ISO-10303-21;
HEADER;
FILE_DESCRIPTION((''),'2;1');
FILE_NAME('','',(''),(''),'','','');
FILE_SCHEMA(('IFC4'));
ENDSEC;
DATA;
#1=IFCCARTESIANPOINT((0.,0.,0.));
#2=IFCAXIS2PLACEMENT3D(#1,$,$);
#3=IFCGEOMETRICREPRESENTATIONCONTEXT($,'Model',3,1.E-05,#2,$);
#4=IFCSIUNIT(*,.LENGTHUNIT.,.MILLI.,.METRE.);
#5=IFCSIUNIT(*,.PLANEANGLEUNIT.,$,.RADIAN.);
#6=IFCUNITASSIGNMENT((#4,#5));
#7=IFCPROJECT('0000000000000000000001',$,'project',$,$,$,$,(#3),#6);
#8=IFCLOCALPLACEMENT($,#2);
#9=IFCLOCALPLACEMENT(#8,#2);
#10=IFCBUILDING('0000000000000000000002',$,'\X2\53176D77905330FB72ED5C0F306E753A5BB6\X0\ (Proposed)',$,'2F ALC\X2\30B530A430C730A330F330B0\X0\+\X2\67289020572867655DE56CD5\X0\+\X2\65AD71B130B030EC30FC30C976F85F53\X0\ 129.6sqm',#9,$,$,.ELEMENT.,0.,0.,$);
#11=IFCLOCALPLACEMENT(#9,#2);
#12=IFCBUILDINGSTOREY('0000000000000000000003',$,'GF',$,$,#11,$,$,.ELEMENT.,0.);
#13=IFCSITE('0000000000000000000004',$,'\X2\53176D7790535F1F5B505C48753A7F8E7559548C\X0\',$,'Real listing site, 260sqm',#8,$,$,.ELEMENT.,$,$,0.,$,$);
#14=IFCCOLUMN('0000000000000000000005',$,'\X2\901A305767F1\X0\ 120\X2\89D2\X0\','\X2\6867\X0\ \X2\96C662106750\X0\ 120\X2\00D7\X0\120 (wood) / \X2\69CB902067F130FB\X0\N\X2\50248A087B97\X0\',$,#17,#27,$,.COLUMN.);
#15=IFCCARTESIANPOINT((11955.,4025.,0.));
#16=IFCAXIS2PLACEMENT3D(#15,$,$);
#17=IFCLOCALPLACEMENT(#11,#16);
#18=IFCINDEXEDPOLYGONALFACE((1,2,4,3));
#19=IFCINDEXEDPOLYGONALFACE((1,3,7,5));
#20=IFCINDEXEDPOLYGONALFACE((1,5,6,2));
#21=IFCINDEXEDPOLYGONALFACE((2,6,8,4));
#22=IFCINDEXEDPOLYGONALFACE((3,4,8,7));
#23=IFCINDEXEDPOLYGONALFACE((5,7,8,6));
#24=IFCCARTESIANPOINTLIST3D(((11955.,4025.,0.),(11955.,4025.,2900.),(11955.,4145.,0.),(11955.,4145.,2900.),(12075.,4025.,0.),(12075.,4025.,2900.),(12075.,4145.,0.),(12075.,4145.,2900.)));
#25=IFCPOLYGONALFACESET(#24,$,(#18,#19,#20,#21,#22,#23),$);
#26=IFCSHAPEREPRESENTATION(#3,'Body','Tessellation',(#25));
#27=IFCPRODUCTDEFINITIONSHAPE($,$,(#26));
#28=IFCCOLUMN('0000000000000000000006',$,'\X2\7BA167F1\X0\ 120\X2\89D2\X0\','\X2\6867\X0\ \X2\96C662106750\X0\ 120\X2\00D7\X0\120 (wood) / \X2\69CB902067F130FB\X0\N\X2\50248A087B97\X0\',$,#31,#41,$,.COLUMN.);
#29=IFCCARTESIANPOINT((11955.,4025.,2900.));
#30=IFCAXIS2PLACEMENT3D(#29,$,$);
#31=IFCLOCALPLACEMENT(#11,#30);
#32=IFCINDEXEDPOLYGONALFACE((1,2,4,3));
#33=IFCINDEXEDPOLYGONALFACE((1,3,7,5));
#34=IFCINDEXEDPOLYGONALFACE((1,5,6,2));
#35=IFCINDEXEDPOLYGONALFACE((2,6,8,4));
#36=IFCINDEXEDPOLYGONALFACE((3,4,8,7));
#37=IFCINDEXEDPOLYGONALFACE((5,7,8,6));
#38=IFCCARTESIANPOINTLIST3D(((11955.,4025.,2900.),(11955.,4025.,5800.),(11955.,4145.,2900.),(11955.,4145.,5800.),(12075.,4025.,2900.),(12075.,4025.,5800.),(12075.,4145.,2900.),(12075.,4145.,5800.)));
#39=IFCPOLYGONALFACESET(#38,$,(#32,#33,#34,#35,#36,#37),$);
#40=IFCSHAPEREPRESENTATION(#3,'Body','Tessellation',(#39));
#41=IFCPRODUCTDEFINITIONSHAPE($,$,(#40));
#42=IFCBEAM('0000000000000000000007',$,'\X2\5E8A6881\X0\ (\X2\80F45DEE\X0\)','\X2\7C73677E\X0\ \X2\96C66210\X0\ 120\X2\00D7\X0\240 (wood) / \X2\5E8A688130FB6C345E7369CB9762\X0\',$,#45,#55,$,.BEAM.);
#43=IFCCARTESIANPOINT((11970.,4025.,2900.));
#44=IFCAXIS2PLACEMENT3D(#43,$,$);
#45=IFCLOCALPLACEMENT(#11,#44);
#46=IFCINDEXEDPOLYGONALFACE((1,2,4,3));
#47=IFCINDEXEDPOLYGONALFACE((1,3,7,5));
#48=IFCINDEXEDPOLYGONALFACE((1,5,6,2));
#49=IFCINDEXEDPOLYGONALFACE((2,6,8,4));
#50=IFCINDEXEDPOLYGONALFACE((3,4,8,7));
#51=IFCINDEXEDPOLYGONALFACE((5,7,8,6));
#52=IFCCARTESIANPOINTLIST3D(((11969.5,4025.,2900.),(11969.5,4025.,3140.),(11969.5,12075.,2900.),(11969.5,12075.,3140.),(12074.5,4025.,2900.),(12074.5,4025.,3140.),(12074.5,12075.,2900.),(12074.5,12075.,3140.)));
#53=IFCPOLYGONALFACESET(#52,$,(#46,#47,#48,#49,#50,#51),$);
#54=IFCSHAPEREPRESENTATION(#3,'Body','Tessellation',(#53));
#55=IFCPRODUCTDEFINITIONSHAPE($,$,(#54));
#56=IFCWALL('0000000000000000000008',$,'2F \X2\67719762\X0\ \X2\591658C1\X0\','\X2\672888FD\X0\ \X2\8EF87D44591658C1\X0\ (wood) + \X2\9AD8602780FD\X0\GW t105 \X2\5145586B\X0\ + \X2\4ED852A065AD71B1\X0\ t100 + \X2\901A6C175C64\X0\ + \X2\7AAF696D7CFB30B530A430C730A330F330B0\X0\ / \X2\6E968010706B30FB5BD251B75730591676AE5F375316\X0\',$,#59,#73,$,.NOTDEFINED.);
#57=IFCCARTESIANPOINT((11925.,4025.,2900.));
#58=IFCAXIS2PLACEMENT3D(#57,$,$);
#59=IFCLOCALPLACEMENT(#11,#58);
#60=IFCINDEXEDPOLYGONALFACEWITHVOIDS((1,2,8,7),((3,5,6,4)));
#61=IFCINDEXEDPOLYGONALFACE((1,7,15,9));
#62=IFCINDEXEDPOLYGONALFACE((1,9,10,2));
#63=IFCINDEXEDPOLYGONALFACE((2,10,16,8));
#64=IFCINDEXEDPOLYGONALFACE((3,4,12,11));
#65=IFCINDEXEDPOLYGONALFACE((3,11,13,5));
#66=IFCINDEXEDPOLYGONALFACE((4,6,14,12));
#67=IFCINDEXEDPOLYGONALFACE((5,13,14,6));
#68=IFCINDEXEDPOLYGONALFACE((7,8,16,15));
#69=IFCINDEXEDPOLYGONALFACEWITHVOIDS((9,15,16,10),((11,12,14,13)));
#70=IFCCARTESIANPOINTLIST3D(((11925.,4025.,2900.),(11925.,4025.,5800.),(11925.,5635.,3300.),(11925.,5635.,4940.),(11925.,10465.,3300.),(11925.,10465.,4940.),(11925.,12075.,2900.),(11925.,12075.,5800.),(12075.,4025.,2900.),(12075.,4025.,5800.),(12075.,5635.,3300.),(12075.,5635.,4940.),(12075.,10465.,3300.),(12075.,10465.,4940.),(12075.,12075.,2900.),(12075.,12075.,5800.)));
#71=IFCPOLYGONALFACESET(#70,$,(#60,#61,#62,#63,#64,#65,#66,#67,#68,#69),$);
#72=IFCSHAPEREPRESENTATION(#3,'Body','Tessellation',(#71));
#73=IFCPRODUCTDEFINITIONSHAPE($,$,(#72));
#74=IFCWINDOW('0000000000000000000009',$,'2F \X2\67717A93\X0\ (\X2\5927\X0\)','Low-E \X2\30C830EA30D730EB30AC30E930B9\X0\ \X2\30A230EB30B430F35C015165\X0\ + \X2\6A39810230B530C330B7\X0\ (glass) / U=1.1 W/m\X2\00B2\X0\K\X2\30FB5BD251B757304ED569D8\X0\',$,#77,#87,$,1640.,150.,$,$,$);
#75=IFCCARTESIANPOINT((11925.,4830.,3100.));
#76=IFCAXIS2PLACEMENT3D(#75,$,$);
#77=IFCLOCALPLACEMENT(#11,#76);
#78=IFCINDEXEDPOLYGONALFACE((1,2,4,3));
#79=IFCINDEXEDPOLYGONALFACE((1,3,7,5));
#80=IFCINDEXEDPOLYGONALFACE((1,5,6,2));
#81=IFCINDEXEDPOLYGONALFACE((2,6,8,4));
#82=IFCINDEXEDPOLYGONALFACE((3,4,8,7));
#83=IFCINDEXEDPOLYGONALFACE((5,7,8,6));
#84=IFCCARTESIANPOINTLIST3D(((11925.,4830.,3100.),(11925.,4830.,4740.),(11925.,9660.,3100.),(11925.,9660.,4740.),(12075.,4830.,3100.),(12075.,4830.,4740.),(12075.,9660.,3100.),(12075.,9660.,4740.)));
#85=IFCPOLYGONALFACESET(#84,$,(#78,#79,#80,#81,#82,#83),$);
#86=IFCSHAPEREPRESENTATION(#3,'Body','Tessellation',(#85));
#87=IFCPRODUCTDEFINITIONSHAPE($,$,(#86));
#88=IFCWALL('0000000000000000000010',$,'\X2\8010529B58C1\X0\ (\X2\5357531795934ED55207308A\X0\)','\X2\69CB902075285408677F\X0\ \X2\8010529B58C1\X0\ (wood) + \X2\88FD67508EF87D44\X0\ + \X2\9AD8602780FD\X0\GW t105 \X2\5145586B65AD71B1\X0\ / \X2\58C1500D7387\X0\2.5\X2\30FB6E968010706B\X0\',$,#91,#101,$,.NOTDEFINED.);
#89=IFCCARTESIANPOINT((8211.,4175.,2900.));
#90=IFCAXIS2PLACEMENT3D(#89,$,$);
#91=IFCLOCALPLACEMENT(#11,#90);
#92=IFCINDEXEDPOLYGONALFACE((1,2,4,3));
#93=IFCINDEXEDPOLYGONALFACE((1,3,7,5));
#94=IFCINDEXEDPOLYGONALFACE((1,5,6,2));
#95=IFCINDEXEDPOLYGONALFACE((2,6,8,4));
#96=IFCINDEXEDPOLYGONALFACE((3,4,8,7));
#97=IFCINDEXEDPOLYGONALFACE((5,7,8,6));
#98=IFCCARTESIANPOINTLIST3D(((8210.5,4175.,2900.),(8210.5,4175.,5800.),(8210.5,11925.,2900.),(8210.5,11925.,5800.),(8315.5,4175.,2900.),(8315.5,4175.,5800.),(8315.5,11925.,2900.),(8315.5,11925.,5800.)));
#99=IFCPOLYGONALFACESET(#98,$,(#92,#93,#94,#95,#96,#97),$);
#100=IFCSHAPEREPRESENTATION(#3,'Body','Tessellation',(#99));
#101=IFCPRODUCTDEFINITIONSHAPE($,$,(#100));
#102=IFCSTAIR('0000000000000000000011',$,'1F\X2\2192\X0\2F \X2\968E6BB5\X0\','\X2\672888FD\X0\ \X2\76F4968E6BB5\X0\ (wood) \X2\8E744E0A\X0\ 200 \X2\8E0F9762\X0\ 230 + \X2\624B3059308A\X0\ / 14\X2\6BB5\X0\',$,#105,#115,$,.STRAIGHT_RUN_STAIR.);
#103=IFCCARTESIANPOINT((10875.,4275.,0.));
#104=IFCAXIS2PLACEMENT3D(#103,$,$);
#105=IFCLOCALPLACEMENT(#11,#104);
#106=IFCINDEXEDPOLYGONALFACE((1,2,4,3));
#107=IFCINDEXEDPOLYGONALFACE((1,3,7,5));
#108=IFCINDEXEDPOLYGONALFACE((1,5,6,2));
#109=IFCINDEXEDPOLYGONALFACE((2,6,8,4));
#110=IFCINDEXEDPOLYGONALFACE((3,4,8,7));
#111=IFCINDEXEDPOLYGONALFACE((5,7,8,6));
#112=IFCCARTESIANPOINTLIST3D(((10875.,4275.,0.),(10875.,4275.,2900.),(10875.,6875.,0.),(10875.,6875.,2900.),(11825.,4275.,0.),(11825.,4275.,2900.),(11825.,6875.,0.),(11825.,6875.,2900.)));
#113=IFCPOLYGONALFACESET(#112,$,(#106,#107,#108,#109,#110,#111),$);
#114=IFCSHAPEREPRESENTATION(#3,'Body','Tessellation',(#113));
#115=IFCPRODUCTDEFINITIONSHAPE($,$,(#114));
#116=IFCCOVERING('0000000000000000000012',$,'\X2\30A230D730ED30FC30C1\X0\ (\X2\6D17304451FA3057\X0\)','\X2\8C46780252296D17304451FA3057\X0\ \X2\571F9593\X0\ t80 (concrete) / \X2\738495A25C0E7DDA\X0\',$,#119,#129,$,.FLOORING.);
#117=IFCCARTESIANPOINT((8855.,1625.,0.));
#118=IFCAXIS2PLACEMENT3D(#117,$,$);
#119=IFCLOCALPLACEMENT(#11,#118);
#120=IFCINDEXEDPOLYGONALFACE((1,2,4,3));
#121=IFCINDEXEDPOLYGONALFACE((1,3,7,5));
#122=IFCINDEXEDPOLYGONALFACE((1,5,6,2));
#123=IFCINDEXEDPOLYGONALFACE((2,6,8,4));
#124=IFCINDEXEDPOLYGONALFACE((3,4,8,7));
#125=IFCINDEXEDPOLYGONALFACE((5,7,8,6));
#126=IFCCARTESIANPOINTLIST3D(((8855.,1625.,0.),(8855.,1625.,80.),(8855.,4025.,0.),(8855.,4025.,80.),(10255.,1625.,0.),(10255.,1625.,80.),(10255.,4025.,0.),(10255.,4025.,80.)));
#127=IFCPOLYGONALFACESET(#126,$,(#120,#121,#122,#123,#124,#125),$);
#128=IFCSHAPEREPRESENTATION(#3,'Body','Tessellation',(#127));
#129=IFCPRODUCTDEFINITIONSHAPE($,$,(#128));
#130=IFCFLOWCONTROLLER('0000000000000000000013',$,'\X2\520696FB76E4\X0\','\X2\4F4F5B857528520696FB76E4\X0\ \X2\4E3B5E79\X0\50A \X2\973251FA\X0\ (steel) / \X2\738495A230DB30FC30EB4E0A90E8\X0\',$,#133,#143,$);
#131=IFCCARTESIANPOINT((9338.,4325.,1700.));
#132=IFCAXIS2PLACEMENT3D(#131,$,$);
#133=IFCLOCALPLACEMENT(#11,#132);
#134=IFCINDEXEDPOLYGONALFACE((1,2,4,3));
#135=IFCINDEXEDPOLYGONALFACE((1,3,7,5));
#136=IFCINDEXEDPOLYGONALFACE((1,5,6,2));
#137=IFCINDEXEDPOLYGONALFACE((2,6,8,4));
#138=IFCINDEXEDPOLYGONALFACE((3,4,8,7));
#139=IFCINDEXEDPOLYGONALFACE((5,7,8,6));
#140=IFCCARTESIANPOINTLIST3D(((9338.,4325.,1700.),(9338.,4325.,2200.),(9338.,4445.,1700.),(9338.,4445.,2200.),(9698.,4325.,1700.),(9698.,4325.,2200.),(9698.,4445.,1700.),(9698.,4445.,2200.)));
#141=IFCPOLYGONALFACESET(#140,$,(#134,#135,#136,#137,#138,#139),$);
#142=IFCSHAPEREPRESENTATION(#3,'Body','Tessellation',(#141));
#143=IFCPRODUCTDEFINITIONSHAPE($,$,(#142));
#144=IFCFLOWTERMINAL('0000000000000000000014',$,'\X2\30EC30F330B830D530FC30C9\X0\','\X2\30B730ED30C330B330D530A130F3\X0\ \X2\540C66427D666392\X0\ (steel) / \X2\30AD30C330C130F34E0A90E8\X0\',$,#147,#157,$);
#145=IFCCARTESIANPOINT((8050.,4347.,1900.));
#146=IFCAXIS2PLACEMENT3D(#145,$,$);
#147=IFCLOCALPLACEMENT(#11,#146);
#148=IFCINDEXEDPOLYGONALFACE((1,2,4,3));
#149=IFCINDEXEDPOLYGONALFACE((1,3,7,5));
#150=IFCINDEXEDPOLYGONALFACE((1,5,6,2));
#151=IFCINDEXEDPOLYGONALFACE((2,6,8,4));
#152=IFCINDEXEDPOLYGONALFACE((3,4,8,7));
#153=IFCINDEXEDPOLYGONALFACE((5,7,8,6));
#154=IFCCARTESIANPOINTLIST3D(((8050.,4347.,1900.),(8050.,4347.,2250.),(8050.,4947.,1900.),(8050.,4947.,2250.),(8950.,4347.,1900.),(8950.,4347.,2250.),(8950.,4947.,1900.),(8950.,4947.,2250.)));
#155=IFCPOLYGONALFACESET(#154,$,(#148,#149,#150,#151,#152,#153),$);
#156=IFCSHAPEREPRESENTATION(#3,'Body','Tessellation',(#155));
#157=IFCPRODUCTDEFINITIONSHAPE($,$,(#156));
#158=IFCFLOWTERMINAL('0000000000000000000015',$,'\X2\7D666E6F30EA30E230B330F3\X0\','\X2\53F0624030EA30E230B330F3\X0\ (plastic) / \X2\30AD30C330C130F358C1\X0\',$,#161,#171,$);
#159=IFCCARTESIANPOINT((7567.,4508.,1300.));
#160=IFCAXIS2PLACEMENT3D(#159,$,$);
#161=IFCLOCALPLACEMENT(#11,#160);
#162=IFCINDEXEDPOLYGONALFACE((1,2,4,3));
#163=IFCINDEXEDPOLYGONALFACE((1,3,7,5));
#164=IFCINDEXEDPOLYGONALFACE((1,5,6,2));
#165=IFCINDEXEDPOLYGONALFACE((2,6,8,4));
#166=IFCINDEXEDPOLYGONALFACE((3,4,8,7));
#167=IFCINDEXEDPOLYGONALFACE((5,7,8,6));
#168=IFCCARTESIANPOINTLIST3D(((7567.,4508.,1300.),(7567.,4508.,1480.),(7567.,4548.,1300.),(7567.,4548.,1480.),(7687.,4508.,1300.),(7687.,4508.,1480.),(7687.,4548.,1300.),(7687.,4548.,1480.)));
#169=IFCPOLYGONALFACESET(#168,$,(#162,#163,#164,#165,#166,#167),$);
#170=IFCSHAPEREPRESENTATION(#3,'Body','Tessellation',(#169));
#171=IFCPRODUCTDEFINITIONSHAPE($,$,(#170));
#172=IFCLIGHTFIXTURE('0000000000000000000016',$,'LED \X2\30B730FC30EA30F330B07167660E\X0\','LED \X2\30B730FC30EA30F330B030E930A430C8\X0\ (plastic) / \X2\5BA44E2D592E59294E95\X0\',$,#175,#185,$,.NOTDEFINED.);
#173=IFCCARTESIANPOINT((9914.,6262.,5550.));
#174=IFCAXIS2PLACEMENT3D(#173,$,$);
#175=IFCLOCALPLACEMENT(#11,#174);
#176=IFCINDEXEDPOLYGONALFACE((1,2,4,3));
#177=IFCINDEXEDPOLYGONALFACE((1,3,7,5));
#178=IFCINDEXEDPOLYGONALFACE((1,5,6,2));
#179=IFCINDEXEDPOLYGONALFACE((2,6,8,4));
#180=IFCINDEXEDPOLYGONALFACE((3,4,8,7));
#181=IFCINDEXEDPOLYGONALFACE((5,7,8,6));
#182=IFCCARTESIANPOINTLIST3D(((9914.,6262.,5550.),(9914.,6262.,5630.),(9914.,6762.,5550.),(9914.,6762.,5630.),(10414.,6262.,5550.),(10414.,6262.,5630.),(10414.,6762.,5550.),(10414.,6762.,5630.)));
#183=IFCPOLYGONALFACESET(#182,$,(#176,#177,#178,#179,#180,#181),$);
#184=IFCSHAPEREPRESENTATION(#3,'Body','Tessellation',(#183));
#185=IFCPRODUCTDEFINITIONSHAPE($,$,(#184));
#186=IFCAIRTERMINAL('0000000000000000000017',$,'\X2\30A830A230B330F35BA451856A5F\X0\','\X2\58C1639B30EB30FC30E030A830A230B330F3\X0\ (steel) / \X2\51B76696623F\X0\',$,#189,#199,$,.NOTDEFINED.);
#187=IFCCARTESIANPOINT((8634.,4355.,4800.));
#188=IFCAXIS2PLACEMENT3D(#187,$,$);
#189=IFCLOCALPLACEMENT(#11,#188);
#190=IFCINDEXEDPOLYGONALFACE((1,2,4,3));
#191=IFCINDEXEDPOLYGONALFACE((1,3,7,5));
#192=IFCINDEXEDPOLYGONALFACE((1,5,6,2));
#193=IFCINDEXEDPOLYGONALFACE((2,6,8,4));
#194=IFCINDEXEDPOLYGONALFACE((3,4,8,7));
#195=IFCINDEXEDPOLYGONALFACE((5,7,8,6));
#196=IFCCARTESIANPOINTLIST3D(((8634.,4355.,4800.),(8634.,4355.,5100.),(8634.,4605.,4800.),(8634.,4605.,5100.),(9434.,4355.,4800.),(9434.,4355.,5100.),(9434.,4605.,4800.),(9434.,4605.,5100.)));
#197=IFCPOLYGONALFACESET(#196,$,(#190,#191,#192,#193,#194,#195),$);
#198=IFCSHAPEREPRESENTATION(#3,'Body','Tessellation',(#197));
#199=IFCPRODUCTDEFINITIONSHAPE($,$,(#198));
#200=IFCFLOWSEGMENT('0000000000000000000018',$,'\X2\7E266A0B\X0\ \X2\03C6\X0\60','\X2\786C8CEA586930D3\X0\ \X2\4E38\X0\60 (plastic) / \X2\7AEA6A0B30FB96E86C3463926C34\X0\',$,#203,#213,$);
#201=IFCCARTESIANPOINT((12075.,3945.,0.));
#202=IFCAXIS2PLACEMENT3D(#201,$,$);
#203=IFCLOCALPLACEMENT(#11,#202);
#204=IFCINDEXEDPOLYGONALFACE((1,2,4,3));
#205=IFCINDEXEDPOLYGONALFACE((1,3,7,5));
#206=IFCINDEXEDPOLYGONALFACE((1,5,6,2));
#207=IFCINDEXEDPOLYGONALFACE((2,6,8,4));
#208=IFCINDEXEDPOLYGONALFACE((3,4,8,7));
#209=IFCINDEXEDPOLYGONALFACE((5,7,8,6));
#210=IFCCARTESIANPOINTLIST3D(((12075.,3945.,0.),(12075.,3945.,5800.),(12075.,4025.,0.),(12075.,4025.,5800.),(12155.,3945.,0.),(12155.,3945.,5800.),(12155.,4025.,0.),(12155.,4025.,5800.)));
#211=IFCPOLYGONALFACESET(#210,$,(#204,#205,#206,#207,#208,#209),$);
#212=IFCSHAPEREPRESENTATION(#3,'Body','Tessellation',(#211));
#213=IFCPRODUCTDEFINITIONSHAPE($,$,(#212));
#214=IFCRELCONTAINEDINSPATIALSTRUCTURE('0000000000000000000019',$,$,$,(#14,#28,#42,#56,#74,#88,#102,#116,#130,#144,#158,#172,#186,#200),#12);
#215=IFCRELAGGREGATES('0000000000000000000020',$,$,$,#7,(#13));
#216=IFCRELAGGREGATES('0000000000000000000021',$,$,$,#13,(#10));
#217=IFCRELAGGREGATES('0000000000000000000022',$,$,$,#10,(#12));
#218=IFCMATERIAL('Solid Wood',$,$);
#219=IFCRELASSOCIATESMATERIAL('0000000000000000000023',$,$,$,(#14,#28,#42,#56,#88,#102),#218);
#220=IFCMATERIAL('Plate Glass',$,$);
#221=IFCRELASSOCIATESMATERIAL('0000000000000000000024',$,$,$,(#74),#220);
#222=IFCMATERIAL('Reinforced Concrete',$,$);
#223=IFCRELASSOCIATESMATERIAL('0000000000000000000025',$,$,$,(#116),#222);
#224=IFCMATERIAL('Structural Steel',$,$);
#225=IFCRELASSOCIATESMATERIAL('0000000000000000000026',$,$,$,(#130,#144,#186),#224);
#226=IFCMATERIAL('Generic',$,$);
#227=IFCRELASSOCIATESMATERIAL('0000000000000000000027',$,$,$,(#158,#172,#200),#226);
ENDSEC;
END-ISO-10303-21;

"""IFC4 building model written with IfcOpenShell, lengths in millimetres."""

from ifc_helpers import new_model, si_unit, frame, frame_2d, origin, place, context, project, spatial, rectangle, extrude, material, element, fill, save


model = new_model("IFC4")

# Units and contexts
model_context = context("Model", 3, precision=1e-05, world=origin())
ifc_project = project(units=[si_unit("LENGTHUNIT", "METRE", prefix="MILLI"), si_unit("PLANEANGLEUNIT", "RADIAN")], contexts=[model_context])

# Site, building, storey
site_placement = place(None, origin())
site = spatial("IfcSite", under=ifc_project, at=site_placement, Name="北海道弟子屈町美留和", ObjectType="Real listing site, 260sqm", CompositionType="ELEMENT", RefElevation=0.0)
building_placement = place(site_placement, origin())
building = spatial("IfcBuilding", under=site, at=building_placement, Name="北海道・狭小の町家 (Proposed)", ObjectType="2F ALCサイディング+木造在来工法+断熱グレード相当 129.6sqm", CompositionType="ELEMENT", ElevationOfRefHeight=0.0, ElevationOfTerrain=0.0)
storey_placement = place(building_placement, origin())
storey = spatial("IfcBuildingStorey", under=building, at=storey_placement, Name="GF", CompositionType="ELEMENT", Elevation=0.0)

# Columns
ifc_material_1 = material(Name="Solid Wood")
column_1_placement = place(storey_placement, frame((11955.0, 4025.0, 0.0)))
element("IfcColumn", 1, at=column_1_placement, inside=storey, material=ifc_material_1, Name="通し柱 120角", Description="桧 集成材 120×120 (wood) / 構造柱・N値計算", PredefinedType="COLUMN", context=model_context, shape_type="SweptSolid", body=[
    extrude(rectangle(XDim=120.0, YDim=120.0, at=frame_2d((60.0, 60.0))), frame((11955.0, 4025.0, 0.0)), (0.0, 0.0, 1.0), 2900.0),
])
column_2_placement = place(storey_placement, frame((11955.0, 4025.0, 2900.0)))
element("IfcColumn", 2, at=column_2_placement, inside=storey, material=ifc_material_1, Name="管柱 120角", Description="桧 集成材 120×120 (wood) / 構造柱・N値計算", PredefinedType="COLUMN", context=model_context, shape_type="SweptSolid", body=[
    extrude(rectangle(XDim=120.0, YDim=120.0, at=frame_2d((60.0, 60.0))), frame((11955.0, 4025.0, 2900.0)), (0.0, 0.0, 1.0), 2900.0),
])

# Beam
beam_1_placement = place(storey_placement, frame((11970.0, 4025.0, 2900.0)))
element("IfcBeam", 3, at=beam_1_placement, inside=storey, material=ifc_material_1, Name="床梁 (胴差)", Description="米松 集成 120×240 (wood) / 床梁・水平構面", PredefinedType="BEAM", context=model_context, shape_type="SweptSolid", body=[
    extrude(rectangle(XDim=105.0, YDim=8050.0, at=frame_2d((52.0, 4025.0))), frame((11970.0, 4025.0, 2900.0)), (0.0, 0.0, 1.0), 240.0),
])

# Shared definitions
ifc_material_2 = material(Name="Plate Glass")

# Wall, opening, window
wall_1_placement = place(storey_placement, frame((11925.0, 4025.0, 2900.0)))
wall_1 = element("IfcWall", 4, at=wall_1_placement, inside=storey, material=ifc_material_1, Name="2F 東面 外壁", Description="木製 軸組外壁 (wood) + 高性能GW t105 充填 + 付加断熱 t100 + 通気層 + 窯業系サイディング / 準耐火・寒冷地外皮強化", PredefinedType="NOTDEFINED", context=model_context, shape_type="SweptSolid", body=[
    extrude(rectangle(XDim=150.0, YDim=8050.0, at=frame_2d((75.0, 4025.0))), frame((11925.0, 4025.0, 2900.0)), (0.0, 0.0, 1.0), 2900.0),
])
opening_1_placement = place(storey_placement, frame((11925.0, 4830.0, 3100.0)))
opening_1 = element("IfcOpeningElement", 5, at=opening_1_placement, cuts=wall_1, PredefinedType="NOTDEFINED", context=model_context, shape_type="SweptSolid", body=[
    extrude(rectangle(XDim=150.0, YDim=4830.0, at=frame_2d((75.0, 2415.0))), frame((11925.0, 4830.0, 3100.0)), (0.0, 0.0, 1.0), 1640.0),
])
window_1_placement = place(storey_placement, frame((11925.0, 4830.0, 3100.0)))
window_1 = element("IfcWindow", 6, at=window_1_placement, inside=storey, material=ifc_material_2, Name="2F 東窓 (大)", Description="Low-E トリプルガラス アルゴン封入 + 樹脂サッシ (glass) / U=1.1 W/m²K・寒冷地仕様", OverallHeight=1640.0, OverallWidth=150.0, context=model_context, shape_type="SweptSolid", body=[
    extrude(rectangle(XDim=150.0, YDim=4830.0, at=frame_2d((75.0, 2415.0))), frame((11925.0, 4830.0, 3100.0)), (0.0, 0.0, 1.0), 1640.0),
])
fill(opening_1, window_1)

# Wall
wall_2_placement = place(storey_placement, frame((8211.0, 4175.0, 2900.0)))
element("IfcWall", 7, at=wall_2_placement, inside=storey, material=ifc_material_1, Name="耐力壁 (南北間仕切り)", Description="構造用合板 耐力壁 (wood) + 製材軸組 + 高性能GW t105 充填断熱 / 壁倍率2.5・準耐火", PredefinedType="NOTDEFINED", context=model_context, shape_type="SweptSolid", body=[
    extrude(rectangle(XDim=105.0, YDim=7750.0, at=frame_2d((52.0, 3875.0))), frame((8211.0, 4175.0, 2900.0)), (0.0, 0.0, 1.0), 2900.0),
])

# Stair
stair_placement = place(storey_placement, frame((10875.0, 4275.0, 0.0)))
element("IfcStair", 8, at=stair_placement, inside=storey, material=ifc_material_1, Name="1F→2F 階段", Description="木製 直階段 (wood) 蹴上 200 踏面 230 + 手すり / 14段", PredefinedType="STRAIGHT_RUN_STAIR", context=model_context, shape_type="SweptSolid", body=[
    extrude(rectangle(XDim=950.0, YDim=2600.0, at=frame_2d((475.0, 1300.0))), frame((10875.0, 4275.0, 0.0)), (0.0, 0.0, 1.0), 2900.0),
])

# Covering
ifc_material_3 = material(Name="Reinforced Concrete")
covering_placement = place(storey_placement, frame((8855.0, 1625.0, 0.0)))
element("IfcCovering", 9, at=covering_placement, inside=storey, material=ifc_material_3, Name="アプローチ (洗い出し)", Description="豆砂利洗い出し 土間 t80 (concrete) / 玄関導線", PredefinedType="FLOORING", context=model_context, shape_type="SweptSolid", body=[
    extrude(rectangle(XDim=1400.0, YDim=2400.0, at=frame_2d((700.0, 1200.0))), frame((8855.0, 1625.0, 0.0)), (0.0, 0.0, 1.0), 80.0),
])

# Flow controller
ifc_material_4 = material(Name="Structural Steel")
flow_controller_placement = place(storey_placement, frame((9338.0, 4325.0, 1700.0)))
element("IfcFlowController", 10, at=flow_controller_placement, inside=storey, material=ifc_material_4, Name="分電盤", Description="住宅用分電盤 主幹50A 露出 (steel) / 玄関ホール上部", context=model_context, shape_type="SweptSolid", body=[
    extrude(rectangle(XDim=360.0, YDim=120.0, at=frame_2d((180.0, 60.0))), frame((9338.0, 4325.0, 1700.0)), (0.0, 0.0, 1.0), 500.0),
])

# Flow terminals
flow_terminal_1_placement = place(storey_placement, frame((8050.0, 4347.0, 1900.0)))
element("IfcFlowTerminal", 11, at=flow_terminal_1_placement, inside=storey, material=ifc_material_4, Name="レンジフード", Description="シロッコファン 同時給排 (steel) / キッチン上部", context=model_context, shape_type="SweptSolid", body=[
    extrude(rectangle(XDim=900.0, YDim=600.0, at=frame_2d((450.0, 300.0))), frame((8050.0, 4347.0, 1900.0)), (0.0, 0.0, 1.0), 350.0),
])
ifc_material_5 = material(Name="Generic")
flow_terminal_2_placement = place(storey_placement, frame((7567.0, 4508.0, 1300.0)))
element("IfcFlowTerminal", 12, at=flow_terminal_2_placement, inside=storey, material=ifc_material_5, Name="給湯リモコン", Description="台所リモコン (plastic) / キッチン壁", context=model_context, shape_type="SweptSolid", body=[
    extrude(rectangle(XDim=120.0, YDim=40.0, at=frame_2d((60.0, 20.0))), frame((7567.0, 4508.0, 1300.0)), (0.0, 0.0, 1.0), 180.0),
])

# Light fixture
light_fixture_placement = place(storey_placement, frame((9914.0, 6262.0, 5550.0)))
element("IfcLightFixture", 13, at=light_fixture_placement, inside=storey, material=ifc_material_5, Name="LED シーリング照明", Description="LED シーリングライト (plastic) / 室中央天井", PredefinedType="NOTDEFINED", context=model_context, shape_type="SweptSolid", body=[
    extrude(rectangle(XDim=500.0, YDim=500.0, at=frame_2d((250.0, 250.0))), frame((9914.0, 6262.0, 5550.0)), (0.0, 0.0, 1.0), 80.0),
])

# Air terminal
air_terminal_placement = place(storey_placement, frame((8634.0, 4355.0, 4800.0)))
element("IfcAirTerminal", 14, at=air_terminal_placement, inside=storey, material=ifc_material_4, Name="エアコン室内機", Description="壁掛ルームエアコン (steel) / 冷暖房", PredefinedType="NOTDEFINED", context=model_context, shape_type="SweptSolid", body=[
    extrude(rectangle(XDim=800.0, YDim=250.0, at=frame_2d((400.0, 125.0))), frame((8634.0, 4355.0, 4800.0)), (0.0, 0.0, 1.0), 300.0),
])

# Flow segment
flow_segment_placement = place(storey_placement, frame((12075.0, 3945.0, 0.0)))
element("IfcFlowSegment", 15, at=flow_segment_placement, inside=storey, material=ifc_material_5, Name="縦樋 φ60", Description="硬質塩ビ 丸60 (plastic) / 竪樋・雨水排水", context=model_context, shape_type="SweptSolid", body=[
    extrude(rectangle(XDim=80.0, YDim=80.0, at=frame_2d((40.0, 40.0))), frame((12075.0, 3945.0, 0.0)), (0.0, 0.0, 1.0), 5800.0),
])

save(model, "model.ifc")
